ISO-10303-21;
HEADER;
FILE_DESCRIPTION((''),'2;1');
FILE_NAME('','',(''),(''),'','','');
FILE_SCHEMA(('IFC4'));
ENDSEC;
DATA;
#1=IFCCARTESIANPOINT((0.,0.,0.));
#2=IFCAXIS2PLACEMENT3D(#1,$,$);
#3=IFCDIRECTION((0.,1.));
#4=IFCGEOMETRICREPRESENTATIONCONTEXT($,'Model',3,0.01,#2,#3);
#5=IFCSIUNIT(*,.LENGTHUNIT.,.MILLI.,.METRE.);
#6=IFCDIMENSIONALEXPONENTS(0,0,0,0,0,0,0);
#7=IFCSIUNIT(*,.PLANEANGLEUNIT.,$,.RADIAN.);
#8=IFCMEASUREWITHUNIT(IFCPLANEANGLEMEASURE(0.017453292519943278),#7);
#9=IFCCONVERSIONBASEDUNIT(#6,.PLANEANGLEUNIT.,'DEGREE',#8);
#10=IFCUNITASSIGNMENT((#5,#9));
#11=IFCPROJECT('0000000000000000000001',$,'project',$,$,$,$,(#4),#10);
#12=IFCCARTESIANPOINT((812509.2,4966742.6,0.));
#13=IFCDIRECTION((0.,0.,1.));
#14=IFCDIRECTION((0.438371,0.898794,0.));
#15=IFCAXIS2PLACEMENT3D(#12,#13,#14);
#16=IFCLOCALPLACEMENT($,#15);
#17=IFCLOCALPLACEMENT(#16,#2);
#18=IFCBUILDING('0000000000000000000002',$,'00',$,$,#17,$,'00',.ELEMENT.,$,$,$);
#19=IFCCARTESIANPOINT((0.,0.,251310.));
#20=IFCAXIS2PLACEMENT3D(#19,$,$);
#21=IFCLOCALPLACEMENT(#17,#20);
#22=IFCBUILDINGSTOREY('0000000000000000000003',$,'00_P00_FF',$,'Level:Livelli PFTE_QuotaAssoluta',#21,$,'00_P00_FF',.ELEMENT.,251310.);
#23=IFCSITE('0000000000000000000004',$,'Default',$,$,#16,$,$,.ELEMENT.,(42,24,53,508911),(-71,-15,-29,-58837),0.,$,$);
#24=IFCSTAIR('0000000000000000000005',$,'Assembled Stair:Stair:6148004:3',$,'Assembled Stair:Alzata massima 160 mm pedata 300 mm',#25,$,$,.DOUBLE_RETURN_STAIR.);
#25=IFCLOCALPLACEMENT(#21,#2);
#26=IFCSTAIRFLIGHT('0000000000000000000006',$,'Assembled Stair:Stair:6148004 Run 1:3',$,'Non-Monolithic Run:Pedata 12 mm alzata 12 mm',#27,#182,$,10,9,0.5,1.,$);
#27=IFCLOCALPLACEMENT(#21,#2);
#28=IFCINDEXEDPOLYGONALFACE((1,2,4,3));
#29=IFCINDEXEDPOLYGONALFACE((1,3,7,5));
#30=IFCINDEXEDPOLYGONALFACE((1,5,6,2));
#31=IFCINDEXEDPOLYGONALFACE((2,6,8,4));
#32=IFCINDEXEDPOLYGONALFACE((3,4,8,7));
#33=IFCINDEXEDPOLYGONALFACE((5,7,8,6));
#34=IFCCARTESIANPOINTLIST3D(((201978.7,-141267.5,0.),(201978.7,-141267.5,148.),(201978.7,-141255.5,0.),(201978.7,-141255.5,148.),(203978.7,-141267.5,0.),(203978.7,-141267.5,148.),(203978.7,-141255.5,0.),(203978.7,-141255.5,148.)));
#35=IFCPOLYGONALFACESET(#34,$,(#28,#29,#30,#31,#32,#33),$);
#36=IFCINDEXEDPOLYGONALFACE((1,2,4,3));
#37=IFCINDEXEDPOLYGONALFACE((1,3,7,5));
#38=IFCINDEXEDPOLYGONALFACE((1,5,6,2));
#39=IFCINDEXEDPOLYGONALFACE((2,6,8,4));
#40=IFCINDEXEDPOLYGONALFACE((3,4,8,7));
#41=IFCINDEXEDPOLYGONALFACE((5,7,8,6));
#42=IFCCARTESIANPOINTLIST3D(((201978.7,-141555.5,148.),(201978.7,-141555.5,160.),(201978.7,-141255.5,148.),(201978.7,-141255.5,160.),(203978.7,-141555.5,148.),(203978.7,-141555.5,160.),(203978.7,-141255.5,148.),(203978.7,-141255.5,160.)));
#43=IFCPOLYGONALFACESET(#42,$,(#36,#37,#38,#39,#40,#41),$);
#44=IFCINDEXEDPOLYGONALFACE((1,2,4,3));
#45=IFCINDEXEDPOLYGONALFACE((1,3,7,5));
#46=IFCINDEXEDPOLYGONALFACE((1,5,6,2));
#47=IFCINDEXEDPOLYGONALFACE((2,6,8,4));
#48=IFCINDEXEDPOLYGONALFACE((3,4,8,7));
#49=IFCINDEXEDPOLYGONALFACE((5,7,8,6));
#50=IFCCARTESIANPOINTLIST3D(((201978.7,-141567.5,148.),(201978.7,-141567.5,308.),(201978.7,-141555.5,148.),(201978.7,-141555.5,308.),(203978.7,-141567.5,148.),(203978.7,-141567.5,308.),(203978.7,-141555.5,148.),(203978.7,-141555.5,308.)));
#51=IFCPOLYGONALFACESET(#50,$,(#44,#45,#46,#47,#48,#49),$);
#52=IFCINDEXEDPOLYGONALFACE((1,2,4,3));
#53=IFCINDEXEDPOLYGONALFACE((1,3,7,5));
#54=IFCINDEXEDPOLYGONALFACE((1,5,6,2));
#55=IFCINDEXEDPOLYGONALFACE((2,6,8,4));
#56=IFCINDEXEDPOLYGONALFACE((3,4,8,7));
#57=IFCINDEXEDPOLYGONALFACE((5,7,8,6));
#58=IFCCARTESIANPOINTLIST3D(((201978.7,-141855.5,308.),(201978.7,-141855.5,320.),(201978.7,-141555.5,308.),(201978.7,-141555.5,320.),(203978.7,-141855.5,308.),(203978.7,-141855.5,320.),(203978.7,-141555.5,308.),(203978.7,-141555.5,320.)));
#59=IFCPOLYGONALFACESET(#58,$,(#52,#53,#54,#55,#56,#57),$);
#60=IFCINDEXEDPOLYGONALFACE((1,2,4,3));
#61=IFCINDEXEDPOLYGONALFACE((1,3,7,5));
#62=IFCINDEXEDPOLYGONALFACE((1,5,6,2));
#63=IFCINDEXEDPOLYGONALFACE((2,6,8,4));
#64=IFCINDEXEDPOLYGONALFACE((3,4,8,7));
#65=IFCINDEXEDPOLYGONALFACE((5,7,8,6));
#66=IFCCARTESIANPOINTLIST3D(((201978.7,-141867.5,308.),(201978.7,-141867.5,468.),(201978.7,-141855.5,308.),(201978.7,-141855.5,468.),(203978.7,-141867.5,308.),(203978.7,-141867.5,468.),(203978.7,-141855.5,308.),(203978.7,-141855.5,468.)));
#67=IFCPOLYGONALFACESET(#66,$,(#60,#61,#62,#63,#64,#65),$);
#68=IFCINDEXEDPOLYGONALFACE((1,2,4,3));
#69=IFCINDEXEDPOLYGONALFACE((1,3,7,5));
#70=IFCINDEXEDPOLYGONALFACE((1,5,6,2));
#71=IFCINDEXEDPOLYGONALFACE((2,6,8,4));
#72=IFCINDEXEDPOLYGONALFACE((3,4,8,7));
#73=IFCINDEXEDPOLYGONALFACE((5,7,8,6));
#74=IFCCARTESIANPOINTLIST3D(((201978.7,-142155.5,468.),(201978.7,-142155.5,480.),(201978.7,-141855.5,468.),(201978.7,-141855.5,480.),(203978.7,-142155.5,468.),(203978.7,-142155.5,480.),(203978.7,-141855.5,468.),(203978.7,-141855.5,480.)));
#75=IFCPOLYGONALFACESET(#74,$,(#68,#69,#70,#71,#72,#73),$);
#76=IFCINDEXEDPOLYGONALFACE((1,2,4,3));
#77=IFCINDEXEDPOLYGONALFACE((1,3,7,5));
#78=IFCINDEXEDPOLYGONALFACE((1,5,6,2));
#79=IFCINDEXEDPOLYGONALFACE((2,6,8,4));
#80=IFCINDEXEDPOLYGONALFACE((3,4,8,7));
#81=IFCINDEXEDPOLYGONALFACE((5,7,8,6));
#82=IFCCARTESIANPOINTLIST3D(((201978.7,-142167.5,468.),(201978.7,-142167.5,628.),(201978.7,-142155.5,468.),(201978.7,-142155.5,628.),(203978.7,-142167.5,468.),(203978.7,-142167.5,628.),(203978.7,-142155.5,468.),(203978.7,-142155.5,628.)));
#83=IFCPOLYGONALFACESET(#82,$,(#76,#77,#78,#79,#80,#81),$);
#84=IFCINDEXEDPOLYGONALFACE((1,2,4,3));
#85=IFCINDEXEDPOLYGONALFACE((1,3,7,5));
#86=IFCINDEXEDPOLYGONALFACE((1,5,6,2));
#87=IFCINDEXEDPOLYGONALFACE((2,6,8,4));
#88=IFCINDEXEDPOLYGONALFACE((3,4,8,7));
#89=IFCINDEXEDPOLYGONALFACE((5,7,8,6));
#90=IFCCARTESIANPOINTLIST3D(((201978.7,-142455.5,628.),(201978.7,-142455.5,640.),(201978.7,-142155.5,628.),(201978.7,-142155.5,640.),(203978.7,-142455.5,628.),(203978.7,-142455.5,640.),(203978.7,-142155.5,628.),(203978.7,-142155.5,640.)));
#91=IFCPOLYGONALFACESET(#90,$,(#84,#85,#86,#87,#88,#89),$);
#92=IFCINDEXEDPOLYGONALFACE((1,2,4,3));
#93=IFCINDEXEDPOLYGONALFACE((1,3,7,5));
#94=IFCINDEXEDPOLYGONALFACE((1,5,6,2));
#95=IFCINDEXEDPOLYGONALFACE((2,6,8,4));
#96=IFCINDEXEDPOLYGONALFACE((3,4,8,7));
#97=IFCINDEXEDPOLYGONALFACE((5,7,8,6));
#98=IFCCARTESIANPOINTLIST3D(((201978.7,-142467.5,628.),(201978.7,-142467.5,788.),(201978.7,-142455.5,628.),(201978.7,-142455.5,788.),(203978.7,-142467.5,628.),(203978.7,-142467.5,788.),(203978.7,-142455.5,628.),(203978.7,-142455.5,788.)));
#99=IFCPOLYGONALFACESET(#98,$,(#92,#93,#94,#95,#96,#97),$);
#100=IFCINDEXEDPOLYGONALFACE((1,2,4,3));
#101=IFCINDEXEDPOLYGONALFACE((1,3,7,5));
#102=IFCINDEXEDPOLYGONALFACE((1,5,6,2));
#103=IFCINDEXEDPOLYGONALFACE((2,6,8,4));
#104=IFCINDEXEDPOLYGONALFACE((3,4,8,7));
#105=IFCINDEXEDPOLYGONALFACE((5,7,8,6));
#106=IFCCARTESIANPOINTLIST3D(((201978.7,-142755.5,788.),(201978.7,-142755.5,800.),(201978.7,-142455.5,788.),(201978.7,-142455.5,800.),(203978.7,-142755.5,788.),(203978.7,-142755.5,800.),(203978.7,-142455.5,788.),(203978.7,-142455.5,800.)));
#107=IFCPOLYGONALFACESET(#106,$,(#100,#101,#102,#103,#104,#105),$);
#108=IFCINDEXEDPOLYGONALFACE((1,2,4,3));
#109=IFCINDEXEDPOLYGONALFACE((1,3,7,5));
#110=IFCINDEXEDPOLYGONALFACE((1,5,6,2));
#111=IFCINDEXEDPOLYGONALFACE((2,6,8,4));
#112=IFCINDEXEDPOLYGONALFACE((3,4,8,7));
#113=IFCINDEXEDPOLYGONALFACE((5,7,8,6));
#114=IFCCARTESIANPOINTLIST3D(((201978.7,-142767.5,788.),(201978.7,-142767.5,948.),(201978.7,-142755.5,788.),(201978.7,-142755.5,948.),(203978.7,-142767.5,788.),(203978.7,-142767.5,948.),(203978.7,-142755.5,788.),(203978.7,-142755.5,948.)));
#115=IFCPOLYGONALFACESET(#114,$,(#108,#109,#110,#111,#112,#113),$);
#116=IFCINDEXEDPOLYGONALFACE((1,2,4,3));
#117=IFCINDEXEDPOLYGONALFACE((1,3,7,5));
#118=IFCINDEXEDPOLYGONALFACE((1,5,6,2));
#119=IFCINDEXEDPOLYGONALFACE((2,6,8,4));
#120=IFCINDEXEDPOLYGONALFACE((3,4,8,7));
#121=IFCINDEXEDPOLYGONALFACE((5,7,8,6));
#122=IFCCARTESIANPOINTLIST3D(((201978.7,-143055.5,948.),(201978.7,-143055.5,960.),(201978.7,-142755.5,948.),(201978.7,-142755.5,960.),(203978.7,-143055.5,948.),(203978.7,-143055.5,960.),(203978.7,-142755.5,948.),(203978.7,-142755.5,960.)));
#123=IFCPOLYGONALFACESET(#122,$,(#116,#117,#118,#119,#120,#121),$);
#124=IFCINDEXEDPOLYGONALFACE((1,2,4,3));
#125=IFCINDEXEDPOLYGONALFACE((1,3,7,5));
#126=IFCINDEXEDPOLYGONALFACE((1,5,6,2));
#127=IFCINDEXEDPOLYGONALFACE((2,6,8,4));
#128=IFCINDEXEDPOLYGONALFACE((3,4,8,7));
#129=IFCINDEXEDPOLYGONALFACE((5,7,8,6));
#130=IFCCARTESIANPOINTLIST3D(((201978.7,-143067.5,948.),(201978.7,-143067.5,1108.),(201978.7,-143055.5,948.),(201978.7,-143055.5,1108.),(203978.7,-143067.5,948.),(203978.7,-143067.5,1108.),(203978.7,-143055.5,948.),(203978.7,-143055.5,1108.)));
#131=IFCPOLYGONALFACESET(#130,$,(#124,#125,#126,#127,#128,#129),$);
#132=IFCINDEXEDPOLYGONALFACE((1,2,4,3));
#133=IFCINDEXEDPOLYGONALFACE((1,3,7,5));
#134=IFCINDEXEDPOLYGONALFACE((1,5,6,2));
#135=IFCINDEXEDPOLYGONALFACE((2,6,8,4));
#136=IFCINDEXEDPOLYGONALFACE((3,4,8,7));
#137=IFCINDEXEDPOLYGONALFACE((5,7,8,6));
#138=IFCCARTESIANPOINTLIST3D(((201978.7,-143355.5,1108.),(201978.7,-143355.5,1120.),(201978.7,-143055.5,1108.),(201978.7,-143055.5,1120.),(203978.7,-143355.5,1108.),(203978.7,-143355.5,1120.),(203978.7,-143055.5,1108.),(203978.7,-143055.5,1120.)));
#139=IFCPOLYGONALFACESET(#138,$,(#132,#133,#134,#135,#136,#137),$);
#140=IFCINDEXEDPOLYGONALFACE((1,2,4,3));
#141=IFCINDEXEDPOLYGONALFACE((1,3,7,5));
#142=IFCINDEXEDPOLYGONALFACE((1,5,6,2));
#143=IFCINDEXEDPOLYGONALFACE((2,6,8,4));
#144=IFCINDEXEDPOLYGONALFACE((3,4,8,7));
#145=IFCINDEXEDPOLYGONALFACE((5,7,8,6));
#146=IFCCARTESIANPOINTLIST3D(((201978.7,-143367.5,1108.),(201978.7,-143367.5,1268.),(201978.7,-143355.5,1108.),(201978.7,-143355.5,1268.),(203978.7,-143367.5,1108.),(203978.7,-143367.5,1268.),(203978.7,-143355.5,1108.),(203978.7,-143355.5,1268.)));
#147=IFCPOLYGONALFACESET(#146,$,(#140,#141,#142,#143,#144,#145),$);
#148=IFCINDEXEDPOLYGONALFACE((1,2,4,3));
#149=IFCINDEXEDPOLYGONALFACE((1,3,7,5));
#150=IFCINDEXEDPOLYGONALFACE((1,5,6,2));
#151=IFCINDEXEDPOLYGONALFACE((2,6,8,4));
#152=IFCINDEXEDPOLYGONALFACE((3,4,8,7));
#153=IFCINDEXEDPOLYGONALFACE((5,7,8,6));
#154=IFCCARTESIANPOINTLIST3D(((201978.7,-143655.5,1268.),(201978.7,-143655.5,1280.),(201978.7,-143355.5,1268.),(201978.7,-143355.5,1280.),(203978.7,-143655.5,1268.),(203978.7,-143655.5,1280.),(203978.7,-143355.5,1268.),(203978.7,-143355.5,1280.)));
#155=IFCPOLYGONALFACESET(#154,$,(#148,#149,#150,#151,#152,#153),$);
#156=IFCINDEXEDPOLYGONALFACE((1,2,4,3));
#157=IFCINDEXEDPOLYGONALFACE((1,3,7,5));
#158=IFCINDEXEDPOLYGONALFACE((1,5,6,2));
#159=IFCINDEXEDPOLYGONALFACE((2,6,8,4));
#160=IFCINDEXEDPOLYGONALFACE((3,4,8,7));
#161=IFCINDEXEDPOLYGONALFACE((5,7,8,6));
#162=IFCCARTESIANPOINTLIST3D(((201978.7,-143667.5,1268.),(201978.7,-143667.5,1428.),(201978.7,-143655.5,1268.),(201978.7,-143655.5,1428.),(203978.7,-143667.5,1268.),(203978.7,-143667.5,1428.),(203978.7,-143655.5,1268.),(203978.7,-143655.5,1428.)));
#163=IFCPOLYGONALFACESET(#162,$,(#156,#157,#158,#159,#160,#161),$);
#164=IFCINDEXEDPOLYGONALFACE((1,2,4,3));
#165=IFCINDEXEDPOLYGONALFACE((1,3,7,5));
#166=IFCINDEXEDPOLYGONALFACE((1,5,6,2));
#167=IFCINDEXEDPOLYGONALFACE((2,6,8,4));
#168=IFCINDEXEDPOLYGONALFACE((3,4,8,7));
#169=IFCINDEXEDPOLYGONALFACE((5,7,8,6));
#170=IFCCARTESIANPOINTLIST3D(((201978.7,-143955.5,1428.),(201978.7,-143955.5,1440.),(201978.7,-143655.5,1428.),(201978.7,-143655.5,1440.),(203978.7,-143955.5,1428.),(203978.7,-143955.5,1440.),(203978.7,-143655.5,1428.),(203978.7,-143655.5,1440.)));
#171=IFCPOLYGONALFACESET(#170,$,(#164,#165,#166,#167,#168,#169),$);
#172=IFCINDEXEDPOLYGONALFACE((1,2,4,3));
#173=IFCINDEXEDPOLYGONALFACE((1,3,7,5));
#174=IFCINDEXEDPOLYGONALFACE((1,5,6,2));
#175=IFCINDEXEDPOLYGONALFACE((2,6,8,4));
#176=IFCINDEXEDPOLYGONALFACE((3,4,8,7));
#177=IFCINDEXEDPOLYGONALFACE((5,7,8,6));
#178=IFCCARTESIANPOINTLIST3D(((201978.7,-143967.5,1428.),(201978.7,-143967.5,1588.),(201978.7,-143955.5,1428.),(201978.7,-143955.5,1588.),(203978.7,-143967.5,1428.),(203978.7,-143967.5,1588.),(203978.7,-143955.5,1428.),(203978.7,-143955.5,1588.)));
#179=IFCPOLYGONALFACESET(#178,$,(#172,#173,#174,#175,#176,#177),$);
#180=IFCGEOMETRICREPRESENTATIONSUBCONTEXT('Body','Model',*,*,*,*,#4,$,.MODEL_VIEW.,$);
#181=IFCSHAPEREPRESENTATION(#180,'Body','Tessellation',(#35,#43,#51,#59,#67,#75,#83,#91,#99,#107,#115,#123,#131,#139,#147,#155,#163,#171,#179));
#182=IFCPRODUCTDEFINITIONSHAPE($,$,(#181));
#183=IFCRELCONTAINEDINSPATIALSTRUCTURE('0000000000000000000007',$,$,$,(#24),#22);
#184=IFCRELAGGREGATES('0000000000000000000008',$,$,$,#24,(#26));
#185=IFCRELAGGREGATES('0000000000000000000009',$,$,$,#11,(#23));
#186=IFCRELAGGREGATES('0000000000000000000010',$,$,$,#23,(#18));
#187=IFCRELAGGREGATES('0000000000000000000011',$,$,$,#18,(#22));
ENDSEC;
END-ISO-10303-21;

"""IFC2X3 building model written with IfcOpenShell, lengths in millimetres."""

from ifc_helpers import new_model, entity, si_unit, converted_unit, direction, frame, frame_2d, origin, origin_2d_with_axis, place, context, subcontext, project, spatial, rectangle, extrude, element, aggregate, save


model = new_model("IFC2X3")

# Units and contexts
model_context = context("Model", 3, precision=0.01, world=origin(), true_north=direction((0.0, 1.0)))
body_context = subcontext(model_context, "Body", "Model", "MODEL_VIEW")
ifc_project = project(units=[si_unit("LENGTHUNIT", "METRE", prefix="MILLI"), converted_unit("PLANEANGLEUNIT", "DEGREE", entity("IfcPlaneAngleMeasure", 0.017453292519943278), si_unit("PLANEANGLEUNIT", "RADIAN"), dimensions=[0, 0, 0, 0, 0, 0, 0])], contexts=[model_context])

# Site, building, storey
site_placement = place(None, frame((812509.2, 4966742.6, 0.0), z_axis=(0.0, 0.0, 1.0), x_axis=(0.438371, 0.898794, 0.0)))
site = spatial("IfcSite", under=ifc_project, at=site_placement, Name="Default", CompositionType="ELEMENT", RefLatitude=(42, 24, 53, 508911), RefLongitude=(-71, -15, -29, -58837), RefElevation=0.0)
building_placement = place(site_placement, origin())
building = spatial("IfcBuilding", under=site, at=building_placement, Name="00", LongName="00", CompositionType="ELEMENT")
storey_placement = place(building_placement, frame((0.0, 0.0, 251310.0)))
storey = spatial("IfcBuildingStorey", under=building, at=storey_placement, Name="00_P00_FF", ObjectType="Level:Livelli PFTE_QuotaAssoluta", LongName="00_P00_FF", CompositionType="ELEMENT", Elevation=251310.0)

# Stair
stair_1_placement = place(storey_placement, origin())
stair_1 = element("IfcStair", 1, at=stair_1_placement, inside=storey, Name="Assembled Stair:Stair:6148004:3", ObjectType="Assembled Stair:Alzata massima 160 mm pedata 300 mm", ShapeType="DOUBLE_RETURN_STAIR")

# Stair flight
stair_flight_1_placement = place(stair_1_placement, origin())
stair_flight_1 = element("IfcStairFlight", 2, at=stair_flight_1_placement, Name="Assembled Stair:Stair:6148004 Run 1:3", ObjectType="Non-Monolithic Run:Pedata 12 mm alzata 12 mm", NumberOfRiser=10, NumberOfTreads=9, RiserHeight=0.5, TreadLength=1.0, context=body_context, shape_type="SweptSolid", body=[
    extrude(rectangle(XDim=2000.0, YDim=12.0, at=origin_2d_with_axis()), frame((202978.7, -141261.5, 0.0)), (0.0, 0.0, 1.0), 148.0),
    extrude(rectangle(XDim=300.0, YDim=2000.0, at=frame_2d((0.0, 0.0), x_axis=(1.0, 0.0))), frame((202978.7, -141405.5, 148.0), z_axis=(0.0, 0.0, 1.0), x_axis=(0.0, 1.0, 0.0)), (0.0, 0.0, 1.0), 12.0),
    extrude(rectangle(XDim=2000.0, YDim=12.0, at=origin_2d_with_axis()), frame((202978.7, -141561.5, 148.0)), (0.0, 0.0, 1.0), 160.0),
    extrude(rectangle(XDim=300.0, YDim=2000.0, at=origin_2d_with_axis()), frame((202978.7, -141705.5, 308.0), z_axis=(0.0, 0.0, 1.0), x_axis=(0.0, 1.0, 0.0)), (0.0, 0.0, 1.0), 12.0),
    extrude(rectangle(XDim=2000.0, YDim=12.0, at=origin_2d_with_axis()), frame((202978.7, -141861.5, 308.0)), (0.0, 0.0, 1.0), 160.0),
    extrude(rectangle(XDim=300.0, YDim=2000.0, at=origin_2d_with_axis()), frame((202978.7, -142005.5, 468.0), z_axis=(0.0, 0.0, 1.0), x_axis=(0.0, 1.0, 0.0)), (0.0, 0.0, 1.0), 12.0),
    extrude(rectangle(XDim=2000.0, YDim=12.0, at=origin_2d_with_axis()), frame((202978.7, -142161.5, 468.0)), (0.0, 0.0, 1.0), 160.0),
    extrude(rectangle(XDim=300.0, YDim=2000.0, at=origin_2d_with_axis()), frame((202978.7, -142305.5, 628.0), z_axis=(0.0, 0.0, 1.0), x_axis=(0.0, 1.0, 0.0)), (0.0, 0.0, 1.0), 12.0),
    extrude(rectangle(XDim=2000.0, YDim=12.0, at=origin_2d_with_axis()), frame((202978.7, -142461.5, 628.0)), (0.0, 0.0, 1.0), 160.0),
    extrude(rectangle(XDim=300.0, YDim=2000.0, at=origin_2d_with_axis()), frame((202978.7, -142605.5, 788.0), z_axis=(0.0, 0.0, 1.0), x_axis=(0.0, 1.0, 0.0)), (0.0, 0.0, 1.0), 12.0),
    extrude(rectangle(XDim=2000.0, YDim=12.0, at=origin_2d_with_axis()), frame((202978.7, -142761.5, 788.0)), (0.0, 0.0, 1.0), 160.0),
    extrude(rectangle(XDim=300.0, YDim=2000.0, at=origin_2d_with_axis()), frame((202978.7, -142905.5, 948.0), z_axis=(0.0, 0.0, 1.0), x_axis=(0.0, 1.0, 0.0)), (0.0, 0.0, 1.0), 12.0),
    extrude(rectangle(XDim=2000.0, YDim=12.0, at=origin_2d_with_axis()), frame((202978.7, -143061.5, 948.0)), (0.0, 0.0, 1.0), 160.0),
    extrude(rectangle(XDim=300.0, YDim=2000.0, at=origin_2d_with_axis()), frame((202978.7, -143205.5, 1108.0), z_axis=(0.0, 0.0, 1.0), x_axis=(0.0, 1.0, 0.0)), (0.0, 0.0, 1.0), 12.0),
    extrude(rectangle(XDim=2000.0, YDim=12.0, at=origin_2d_with_axis()), frame((202978.7, -143361.5, 1108.0)), (0.0, 0.0, 1.0), 160.0),
    extrude(rectangle(XDim=300.0, YDim=2000.0, at=origin_2d_with_axis()), frame((202978.7, -143505.5, 1268.0), z_axis=(0.0, 0.0, 1.0), x_axis=(0.0, 1.0, 0.0)), (0.0, 0.0, 1.0), 12.0),
    extrude(rectangle(XDim=2000.0, YDim=12.0, at=origin_2d_with_axis()), frame((202978.7, -143661.5, 1268.0)), (0.0, 0.0, 1.0), 160.0),
    extrude(rectangle(XDim=300.0, YDim=2000.0, at=origin_2d_with_axis()), frame((202978.7, -143805.5, 1428.0), z_axis=(0.0, 0.0, 1.0), x_axis=(0.0, 1.0, 0.0)), (0.0, 0.0, 1.0), 12.0),
    extrude(rectangle(XDim=2000.0, YDim=12.0, at=origin_2d_with_axis()), frame((202978.7, -143961.5, 1428.0)), (0.0, 0.0, 1.0), 160.0),
])
aggregate(stair_1, [stair_flight_1])

save(model, "model.ifc")
